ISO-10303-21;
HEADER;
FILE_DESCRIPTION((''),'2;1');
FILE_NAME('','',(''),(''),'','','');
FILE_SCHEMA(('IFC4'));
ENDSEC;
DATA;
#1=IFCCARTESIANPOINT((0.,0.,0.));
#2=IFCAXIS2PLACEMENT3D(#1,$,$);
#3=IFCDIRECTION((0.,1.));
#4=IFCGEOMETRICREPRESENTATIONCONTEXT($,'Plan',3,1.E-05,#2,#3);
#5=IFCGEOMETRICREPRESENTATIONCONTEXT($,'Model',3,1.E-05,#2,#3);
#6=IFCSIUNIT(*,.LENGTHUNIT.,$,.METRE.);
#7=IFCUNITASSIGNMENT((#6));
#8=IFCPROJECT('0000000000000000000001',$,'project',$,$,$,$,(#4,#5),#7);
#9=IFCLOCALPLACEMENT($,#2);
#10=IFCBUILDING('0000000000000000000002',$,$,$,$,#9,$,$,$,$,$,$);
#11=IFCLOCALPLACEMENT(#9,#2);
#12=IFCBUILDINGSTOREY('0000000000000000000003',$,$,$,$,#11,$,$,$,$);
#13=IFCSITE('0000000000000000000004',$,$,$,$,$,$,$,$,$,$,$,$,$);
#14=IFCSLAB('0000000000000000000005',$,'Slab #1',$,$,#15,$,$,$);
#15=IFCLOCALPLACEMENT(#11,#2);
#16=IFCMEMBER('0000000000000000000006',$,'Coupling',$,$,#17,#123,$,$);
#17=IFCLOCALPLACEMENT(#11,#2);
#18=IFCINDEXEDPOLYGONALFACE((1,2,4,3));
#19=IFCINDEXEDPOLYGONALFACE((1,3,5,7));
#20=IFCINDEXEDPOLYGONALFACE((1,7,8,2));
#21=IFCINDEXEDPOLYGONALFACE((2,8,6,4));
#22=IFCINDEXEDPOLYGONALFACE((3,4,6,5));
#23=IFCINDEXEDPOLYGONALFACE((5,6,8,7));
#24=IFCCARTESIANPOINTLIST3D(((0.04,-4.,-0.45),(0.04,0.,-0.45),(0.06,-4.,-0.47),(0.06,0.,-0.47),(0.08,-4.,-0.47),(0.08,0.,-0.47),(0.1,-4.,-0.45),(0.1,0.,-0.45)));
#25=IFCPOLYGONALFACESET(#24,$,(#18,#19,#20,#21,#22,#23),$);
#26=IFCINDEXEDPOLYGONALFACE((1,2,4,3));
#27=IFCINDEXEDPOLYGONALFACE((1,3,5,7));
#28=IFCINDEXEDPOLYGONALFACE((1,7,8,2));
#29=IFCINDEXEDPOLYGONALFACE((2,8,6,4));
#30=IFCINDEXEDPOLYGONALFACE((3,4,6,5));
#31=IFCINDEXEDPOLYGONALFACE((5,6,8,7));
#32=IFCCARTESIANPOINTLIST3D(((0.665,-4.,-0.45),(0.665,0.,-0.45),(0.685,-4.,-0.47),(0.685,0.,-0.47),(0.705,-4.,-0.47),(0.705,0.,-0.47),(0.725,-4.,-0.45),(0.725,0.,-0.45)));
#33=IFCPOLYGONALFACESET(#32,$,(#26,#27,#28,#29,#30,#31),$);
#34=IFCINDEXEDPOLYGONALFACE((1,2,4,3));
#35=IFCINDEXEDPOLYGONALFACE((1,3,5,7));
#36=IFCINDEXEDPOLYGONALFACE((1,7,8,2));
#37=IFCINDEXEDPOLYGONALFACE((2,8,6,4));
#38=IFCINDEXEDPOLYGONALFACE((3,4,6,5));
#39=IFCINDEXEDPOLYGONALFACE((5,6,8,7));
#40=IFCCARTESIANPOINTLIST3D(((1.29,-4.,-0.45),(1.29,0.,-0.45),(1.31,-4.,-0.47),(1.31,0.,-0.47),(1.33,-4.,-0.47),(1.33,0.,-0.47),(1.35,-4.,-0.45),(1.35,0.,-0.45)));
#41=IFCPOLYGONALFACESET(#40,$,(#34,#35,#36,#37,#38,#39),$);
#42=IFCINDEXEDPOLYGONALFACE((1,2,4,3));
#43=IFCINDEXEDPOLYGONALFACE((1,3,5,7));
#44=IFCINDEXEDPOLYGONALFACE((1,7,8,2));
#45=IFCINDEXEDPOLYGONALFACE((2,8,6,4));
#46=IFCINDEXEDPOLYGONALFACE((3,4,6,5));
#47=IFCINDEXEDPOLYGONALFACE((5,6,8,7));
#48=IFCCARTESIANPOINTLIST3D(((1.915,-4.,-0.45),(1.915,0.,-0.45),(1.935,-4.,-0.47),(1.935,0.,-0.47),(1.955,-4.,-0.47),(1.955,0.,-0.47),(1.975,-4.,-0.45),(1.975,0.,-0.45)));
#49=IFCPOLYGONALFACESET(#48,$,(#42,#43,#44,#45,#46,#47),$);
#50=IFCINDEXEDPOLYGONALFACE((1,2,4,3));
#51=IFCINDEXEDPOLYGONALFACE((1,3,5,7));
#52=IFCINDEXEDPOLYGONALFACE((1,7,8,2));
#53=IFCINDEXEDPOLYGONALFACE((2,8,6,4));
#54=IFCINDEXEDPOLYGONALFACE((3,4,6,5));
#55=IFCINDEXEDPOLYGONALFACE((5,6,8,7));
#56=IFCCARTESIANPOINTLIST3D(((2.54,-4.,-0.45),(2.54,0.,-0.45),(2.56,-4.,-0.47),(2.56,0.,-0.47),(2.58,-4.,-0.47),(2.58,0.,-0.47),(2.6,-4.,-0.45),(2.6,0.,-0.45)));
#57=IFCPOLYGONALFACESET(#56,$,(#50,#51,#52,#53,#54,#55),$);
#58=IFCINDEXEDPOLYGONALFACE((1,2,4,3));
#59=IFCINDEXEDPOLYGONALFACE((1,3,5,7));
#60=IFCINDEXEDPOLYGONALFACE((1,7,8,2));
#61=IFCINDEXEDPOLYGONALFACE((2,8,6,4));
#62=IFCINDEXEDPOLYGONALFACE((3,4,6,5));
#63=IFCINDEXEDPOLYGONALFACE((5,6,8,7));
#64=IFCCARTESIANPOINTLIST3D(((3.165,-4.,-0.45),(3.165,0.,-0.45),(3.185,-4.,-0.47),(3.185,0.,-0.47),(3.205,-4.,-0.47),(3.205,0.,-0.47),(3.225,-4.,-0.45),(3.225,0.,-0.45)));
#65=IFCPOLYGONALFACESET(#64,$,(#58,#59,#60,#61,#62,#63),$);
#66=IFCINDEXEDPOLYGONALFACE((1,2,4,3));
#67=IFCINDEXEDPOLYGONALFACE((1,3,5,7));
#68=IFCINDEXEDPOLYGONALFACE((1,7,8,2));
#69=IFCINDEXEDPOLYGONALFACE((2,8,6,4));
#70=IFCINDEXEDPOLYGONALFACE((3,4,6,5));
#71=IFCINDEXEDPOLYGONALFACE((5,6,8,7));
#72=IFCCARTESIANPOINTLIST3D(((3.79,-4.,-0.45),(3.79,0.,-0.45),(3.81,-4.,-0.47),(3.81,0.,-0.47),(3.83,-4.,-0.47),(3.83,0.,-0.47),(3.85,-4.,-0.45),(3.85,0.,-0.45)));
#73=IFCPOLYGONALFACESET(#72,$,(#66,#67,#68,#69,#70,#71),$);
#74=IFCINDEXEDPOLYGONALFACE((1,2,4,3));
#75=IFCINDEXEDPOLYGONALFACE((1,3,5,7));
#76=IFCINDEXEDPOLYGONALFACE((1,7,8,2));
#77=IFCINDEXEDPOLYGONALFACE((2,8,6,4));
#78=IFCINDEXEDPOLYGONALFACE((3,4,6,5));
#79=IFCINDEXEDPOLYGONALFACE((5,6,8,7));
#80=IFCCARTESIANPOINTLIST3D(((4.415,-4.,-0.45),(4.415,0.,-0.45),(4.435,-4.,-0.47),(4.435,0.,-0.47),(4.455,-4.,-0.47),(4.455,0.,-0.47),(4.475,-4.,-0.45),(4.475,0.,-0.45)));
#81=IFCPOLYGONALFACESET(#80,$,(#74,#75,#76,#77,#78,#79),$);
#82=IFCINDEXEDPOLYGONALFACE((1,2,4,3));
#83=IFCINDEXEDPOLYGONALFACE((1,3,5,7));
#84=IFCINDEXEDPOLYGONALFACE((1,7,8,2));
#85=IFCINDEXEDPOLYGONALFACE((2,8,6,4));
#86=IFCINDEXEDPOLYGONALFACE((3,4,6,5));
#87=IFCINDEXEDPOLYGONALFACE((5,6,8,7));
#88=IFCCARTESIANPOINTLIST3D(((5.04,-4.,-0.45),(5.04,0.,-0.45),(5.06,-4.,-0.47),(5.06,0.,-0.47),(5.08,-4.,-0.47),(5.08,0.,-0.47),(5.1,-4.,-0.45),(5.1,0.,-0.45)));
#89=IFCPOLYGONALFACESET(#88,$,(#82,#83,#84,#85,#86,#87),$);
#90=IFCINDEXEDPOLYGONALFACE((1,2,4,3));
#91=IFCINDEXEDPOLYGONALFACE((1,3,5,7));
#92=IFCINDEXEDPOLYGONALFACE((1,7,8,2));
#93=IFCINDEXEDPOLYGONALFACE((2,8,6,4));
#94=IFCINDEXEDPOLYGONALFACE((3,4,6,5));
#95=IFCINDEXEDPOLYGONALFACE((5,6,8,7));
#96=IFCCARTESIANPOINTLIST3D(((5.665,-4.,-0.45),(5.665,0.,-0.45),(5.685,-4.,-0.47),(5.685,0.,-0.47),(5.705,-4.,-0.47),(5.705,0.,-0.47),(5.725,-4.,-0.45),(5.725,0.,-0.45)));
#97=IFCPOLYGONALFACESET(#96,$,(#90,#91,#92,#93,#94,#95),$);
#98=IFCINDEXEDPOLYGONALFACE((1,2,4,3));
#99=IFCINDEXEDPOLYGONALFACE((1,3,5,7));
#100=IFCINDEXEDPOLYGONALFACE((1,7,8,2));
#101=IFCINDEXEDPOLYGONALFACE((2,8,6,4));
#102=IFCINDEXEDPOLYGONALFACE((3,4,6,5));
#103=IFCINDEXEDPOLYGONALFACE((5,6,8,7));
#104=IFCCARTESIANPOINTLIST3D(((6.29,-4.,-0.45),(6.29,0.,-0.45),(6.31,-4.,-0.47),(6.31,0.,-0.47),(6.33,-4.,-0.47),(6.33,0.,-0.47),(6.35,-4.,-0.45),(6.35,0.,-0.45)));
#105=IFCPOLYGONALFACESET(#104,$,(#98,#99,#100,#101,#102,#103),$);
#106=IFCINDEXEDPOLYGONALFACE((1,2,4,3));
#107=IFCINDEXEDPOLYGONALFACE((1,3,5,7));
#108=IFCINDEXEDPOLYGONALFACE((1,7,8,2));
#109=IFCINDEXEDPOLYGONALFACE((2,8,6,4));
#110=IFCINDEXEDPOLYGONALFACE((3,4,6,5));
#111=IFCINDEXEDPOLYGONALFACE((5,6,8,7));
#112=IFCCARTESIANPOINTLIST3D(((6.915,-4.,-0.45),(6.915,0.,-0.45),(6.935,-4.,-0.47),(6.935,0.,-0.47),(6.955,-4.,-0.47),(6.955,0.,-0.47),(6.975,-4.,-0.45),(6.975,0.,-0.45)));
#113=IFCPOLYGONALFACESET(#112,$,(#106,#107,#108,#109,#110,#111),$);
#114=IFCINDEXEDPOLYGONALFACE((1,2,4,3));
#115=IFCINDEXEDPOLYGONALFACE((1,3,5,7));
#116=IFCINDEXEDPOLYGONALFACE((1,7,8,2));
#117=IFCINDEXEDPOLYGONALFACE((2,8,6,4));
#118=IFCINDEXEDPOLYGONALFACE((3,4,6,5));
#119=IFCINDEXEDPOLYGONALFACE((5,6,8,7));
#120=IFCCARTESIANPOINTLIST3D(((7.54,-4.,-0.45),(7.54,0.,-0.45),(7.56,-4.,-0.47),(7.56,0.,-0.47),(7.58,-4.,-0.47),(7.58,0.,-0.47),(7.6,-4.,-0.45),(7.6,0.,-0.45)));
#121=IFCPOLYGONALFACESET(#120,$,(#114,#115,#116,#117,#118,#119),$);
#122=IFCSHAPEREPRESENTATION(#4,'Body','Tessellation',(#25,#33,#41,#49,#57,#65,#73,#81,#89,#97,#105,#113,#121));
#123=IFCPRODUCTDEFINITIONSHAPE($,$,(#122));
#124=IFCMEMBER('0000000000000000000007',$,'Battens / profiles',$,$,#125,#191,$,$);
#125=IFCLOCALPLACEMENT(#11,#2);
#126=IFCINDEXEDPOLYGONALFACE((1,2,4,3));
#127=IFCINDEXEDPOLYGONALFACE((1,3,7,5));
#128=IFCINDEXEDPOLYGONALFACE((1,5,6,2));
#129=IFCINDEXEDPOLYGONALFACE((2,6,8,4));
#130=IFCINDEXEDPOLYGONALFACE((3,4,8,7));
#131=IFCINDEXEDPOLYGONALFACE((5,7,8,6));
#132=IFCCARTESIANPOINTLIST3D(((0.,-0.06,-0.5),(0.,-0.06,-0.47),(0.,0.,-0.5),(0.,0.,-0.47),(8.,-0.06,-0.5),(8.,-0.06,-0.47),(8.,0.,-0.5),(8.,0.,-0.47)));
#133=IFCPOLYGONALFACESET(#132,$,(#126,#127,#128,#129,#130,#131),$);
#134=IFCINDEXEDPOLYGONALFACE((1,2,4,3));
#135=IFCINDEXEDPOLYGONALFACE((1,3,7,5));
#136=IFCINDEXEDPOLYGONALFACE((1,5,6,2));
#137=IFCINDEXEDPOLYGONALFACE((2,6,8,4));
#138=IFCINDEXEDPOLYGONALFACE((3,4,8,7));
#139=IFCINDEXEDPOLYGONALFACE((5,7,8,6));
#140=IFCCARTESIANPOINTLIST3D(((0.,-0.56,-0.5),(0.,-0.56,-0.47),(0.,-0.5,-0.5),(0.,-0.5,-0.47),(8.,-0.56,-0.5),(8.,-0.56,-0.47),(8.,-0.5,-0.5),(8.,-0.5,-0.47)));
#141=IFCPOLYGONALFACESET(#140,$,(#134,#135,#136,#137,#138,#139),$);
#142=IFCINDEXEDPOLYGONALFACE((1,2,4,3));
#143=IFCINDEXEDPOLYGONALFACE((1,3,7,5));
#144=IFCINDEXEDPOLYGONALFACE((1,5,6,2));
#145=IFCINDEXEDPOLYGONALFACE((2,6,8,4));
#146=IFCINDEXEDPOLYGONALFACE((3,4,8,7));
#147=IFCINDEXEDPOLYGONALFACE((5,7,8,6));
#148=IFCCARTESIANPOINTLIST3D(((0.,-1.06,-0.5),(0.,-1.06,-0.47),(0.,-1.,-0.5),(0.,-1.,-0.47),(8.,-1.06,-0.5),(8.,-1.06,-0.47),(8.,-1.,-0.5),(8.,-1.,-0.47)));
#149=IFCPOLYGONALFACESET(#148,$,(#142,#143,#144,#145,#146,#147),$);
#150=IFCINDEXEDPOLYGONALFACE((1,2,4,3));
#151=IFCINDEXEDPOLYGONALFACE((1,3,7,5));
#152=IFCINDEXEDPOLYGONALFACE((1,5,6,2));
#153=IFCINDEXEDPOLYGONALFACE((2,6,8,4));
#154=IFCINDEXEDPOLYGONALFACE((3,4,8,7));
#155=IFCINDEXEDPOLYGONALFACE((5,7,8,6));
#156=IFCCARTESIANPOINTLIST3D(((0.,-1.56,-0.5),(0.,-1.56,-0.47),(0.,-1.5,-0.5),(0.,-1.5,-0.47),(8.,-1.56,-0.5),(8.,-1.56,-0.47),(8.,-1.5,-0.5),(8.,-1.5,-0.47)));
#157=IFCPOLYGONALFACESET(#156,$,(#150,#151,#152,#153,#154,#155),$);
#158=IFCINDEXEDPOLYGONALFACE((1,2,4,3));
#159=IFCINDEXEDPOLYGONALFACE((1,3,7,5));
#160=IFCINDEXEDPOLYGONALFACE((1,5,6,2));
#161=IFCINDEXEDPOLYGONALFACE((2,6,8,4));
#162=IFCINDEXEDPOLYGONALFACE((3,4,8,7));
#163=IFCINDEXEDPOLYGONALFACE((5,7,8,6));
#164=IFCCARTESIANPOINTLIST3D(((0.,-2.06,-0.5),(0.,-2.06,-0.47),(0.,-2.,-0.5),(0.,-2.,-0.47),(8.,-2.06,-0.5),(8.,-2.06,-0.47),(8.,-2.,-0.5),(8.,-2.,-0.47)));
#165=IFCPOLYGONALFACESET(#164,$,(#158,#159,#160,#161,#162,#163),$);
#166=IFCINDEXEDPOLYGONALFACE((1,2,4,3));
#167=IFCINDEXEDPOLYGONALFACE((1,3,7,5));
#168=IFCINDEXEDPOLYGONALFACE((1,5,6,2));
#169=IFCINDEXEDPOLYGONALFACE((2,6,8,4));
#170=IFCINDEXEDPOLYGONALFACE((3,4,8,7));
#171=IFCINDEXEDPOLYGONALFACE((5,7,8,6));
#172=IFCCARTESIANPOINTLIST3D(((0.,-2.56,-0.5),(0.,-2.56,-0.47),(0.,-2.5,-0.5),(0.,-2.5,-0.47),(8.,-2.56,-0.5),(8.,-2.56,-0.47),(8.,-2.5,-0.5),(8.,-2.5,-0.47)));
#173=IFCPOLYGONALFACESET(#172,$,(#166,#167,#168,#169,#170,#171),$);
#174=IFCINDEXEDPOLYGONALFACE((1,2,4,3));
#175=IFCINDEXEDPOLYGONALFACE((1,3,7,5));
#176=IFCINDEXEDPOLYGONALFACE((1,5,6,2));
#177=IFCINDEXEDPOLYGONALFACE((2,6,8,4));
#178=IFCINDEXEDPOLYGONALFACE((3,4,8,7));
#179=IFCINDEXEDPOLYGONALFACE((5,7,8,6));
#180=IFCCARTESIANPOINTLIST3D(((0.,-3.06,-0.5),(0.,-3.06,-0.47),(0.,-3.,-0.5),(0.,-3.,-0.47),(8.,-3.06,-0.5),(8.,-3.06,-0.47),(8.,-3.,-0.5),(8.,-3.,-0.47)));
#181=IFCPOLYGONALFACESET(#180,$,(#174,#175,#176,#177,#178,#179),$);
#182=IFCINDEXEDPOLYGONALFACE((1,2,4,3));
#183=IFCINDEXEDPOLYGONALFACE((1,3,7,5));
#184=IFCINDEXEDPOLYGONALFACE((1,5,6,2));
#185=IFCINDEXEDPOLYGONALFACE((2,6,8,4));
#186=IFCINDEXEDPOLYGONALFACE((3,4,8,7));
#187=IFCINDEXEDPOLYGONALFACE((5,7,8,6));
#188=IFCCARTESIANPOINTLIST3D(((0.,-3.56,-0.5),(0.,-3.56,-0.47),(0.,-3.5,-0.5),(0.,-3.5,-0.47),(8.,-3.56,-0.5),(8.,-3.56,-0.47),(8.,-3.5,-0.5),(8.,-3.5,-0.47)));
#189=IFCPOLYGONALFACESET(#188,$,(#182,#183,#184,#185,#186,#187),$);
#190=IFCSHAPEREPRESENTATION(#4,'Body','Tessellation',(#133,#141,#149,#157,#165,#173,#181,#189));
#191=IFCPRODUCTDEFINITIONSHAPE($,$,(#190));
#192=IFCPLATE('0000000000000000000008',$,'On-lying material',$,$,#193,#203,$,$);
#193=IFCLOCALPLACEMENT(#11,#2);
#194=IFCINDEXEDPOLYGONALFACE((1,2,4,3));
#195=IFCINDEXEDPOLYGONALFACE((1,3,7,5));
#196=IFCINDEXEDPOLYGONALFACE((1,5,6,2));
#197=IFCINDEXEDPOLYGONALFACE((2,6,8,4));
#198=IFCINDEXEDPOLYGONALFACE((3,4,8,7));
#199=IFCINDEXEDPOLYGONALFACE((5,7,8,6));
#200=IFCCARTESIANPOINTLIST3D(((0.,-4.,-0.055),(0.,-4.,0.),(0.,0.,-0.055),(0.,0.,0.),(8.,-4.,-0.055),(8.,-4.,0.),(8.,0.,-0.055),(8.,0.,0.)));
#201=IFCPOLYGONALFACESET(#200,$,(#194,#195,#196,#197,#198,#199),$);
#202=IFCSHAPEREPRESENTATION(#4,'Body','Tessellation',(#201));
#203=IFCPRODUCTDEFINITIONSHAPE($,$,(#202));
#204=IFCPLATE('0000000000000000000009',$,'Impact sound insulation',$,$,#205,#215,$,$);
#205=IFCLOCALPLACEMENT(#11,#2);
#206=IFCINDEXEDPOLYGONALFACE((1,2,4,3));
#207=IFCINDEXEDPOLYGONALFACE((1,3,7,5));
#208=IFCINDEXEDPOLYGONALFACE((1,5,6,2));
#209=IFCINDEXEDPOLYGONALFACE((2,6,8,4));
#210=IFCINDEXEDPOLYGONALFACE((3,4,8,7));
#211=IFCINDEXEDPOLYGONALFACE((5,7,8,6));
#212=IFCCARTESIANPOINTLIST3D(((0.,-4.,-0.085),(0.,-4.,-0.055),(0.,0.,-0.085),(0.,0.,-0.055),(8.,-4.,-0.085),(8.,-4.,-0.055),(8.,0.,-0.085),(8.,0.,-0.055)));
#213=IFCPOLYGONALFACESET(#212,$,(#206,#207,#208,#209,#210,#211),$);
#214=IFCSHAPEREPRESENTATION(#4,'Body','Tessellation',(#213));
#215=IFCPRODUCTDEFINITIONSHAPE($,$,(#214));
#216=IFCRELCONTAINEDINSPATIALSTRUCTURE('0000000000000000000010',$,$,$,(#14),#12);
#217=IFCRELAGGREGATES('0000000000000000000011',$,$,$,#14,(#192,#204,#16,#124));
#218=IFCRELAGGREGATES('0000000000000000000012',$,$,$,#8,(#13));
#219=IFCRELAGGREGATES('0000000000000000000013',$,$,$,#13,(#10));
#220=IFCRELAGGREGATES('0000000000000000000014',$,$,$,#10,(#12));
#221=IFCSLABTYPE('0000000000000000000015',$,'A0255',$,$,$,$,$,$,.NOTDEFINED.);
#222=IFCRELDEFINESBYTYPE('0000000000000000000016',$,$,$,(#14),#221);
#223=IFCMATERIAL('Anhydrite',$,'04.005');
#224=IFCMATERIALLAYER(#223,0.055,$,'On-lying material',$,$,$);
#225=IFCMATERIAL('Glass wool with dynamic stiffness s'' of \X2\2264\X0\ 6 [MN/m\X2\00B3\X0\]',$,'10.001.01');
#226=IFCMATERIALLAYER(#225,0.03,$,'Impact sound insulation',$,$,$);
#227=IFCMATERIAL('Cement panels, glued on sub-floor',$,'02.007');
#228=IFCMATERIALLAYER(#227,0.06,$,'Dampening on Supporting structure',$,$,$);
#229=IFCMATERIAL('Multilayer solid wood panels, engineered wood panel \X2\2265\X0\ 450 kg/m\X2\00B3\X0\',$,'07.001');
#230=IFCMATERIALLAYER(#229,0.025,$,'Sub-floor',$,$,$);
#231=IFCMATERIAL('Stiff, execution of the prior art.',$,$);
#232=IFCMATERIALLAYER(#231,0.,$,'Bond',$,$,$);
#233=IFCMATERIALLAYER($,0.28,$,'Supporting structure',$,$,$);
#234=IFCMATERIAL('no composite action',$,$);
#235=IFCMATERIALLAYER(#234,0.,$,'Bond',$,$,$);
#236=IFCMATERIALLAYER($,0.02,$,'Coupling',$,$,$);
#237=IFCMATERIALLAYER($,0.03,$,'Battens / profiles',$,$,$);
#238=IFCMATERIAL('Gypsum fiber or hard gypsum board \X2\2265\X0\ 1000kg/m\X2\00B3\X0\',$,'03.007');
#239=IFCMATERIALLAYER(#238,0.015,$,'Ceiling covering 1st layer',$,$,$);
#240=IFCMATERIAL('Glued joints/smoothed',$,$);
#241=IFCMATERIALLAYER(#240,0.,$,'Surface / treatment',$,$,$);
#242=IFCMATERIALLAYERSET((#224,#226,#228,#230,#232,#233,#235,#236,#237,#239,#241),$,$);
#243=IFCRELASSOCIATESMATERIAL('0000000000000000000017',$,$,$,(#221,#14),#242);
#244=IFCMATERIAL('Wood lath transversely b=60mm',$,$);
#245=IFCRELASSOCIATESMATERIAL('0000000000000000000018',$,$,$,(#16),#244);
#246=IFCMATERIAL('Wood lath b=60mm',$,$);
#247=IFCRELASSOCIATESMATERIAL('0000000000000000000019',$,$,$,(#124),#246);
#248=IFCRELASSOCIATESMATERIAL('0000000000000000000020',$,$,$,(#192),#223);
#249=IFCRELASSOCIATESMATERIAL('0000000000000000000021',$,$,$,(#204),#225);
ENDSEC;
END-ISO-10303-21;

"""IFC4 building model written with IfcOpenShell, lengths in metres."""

from ifc_helpers import new_model, si_unit, direction, frame, frame_2d, origin, origin_with_axes, place, context, project, spatial, polyline, rectangle, outline, extrude, material, layer, layer_set, type_object, element, aggregate, save


model = new_model("IFC4")

# Units and contexts
plan_context = context("Plan", 3, precision=1e-05, world=origin(), true_north=direction((0.0, 1.0)))
model_context = context("Model", 3, precision=1e-05, world=origin(), true_north=direction((0.0, 1.0)))
ifc_project = project(units=[si_unit("LENGTHUNIT", "METRE")], contexts=[plan_context, model_context])

# Site, building, storey
site = spatial("IfcSite", under=ifc_project)
building_placement = place(None, origin())
building = spatial("IfcBuilding", under=site, at=building_placement)
storey_placement = place(building_placement, origin())
storey = spatial("IfcBuildingStorey", under=building, at=storey_placement)

# Slab, members, plates
ifc_material_1 = material(Name="Anhydrite", Category="04.005")
ifc_layer_1 = layer(ifc_material_1, 0.055, Name="On-lying material")
ifc_material_2 = material(Name="Glass wool with dynamic stiffness s' of ≤ 6 [MN/m³]", Category="10.001.01")
ifc_layer_2 = layer(ifc_material_2, 0.03, Name="Impact sound insulation")
ifc_material_3 = material(Name="Cement panels, glued on sub-floor", Category="02.007")
ifc_layer_3 = layer(ifc_material_3, 0.06, Name="Dampening on Supporting structure")
ifc_material_4 = material(Name="Multilayer solid wood panels, engineered wood panel ≥ 450 kg/m³", Category="07.001")
ifc_layer_4 = layer(ifc_material_4, 0.025, Name="Sub-floor")
ifc_material_5 = material(Name="Stiff, execution of the prior art.")
ifc_layer_5 = layer(ifc_material_5, 0.0, Name="Bond")
ifc_layer_6 = layer(None, 0.28, Name="Supporting structure")
ifc_material_6 = material(Name="no composite action")
ifc_layer_7 = layer(ifc_material_6, 0.0, Name="Bond")
ifc_layer_8 = layer(None, 0.02, Name="Coupling")
ifc_layer_9 = layer(None, 0.03, Name="Battens / profiles")
ifc_material_7 = material(Name="Gypsum fiber or hard gypsum board ≥ 1000kg/m³", Category="03.007")
ifc_layer_10 = layer(ifc_material_7, 0.015, Name="Ceiling covering 1st layer")
ifc_material_8 = material(Name="Glued joints/smoothed")
ifc_layer_11 = layer(ifc_material_8, 0.0, Name="Surface / treatment")
ifc_layer_set = layer_set([ifc_layer_1, ifc_layer_2, ifc_layer_3, ifc_layer_4, ifc_layer_5, ifc_layer_6, ifc_layer_7, ifc_layer_8, ifc_layer_9, ifc_layer_10, ifc_layer_11])
slab_type = type_object("IfcSlabType", Name="A0255", PredefinedType="NOTDEFINED", material=ifc_layer_set)
slab_placement = place(None, frame((0.0, 0.0, 0.0), z_axis=(0.0, 0.0, -1.0), x_axis=(1.0, 0.0, 0.0)))
slab = element("IfcSlab", 1, at=slab_placement, inside=storey, type_object=slab_type, material=ifc_layer_set, Name="Slab #1")
ifc_material_9 = material(Name="Wood lath transversely b=60mm")
member_1_placement = place(slab_placement, origin())
member_1 = element("IfcMember", 2, at=member_1_placement, material=ifc_material_9, Name="Coupling", context=plan_context, shape_type="SweptSolid", body=[
    extrude(outline(polyline([(0.0, 0.0), (0.06, 0.0), (0.04, 0.02), (0.02, 0.02), (0.0, 0.0)])), frame((0.04, 4.0, 0.45), z_axis=(0.0, -1.0, 0.0), x_axis=(1.0, 0.0, 0.0)), (0.0, 0.0, 1.0), 4.0),
    extrude(outline(polyline([(0.0, 0.0), (0.06, 0.0), (0.04, 0.02), (0.02, 0.02), (0.0, 0.0)])), frame((0.665, 4.0, 0.45), z_axis=(0.0, -1.0, 0.0), x_axis=(1.0, 0.0, 0.0)), (0.0, 0.0, 1.0), 4.0),
    extrude(outline(polyline([(0.0, 0.0), (0.06, 0.0), (0.04, 0.02), (0.02, 0.02), (0.0, 0.0)])), frame((1.29, 4.0, 0.45), z_axis=(0.0, -1.0, 0.0), x_axis=(1.0, 0.0, 0.0)), (0.0, 0.0, 1.0), 4.0),
    extrude(outline(polyline([(0.0, 0.0), (0.06, 0.0), (0.04, 0.02), (0.02, 0.02), (0.0, 0.0)])), frame((1.915, 4.0, 0.45), z_axis=(0.0, -1.0, 0.0), x_axis=(1.0, 0.0, 0.0)), (0.0, 0.0, 1.0), 4.0),
    extrude(outline(polyline([(0.0, 0.0), (0.06, 0.0), (0.04, 0.02), (0.02, 0.02), (0.0, 0.0)])), frame((2.54, 4.0, 0.45), z_axis=(0.0, -1.0, 0.0), x_axis=(1.0, 0.0, 0.0)), (0.0, 0.0, 1.0), 4.0),
    extrude(outline(polyline([(0.0, 0.0), (0.06, 0.0), (0.04, 0.02), (0.02, 0.02), (0.0, 0.0)])), frame((3.165, 4.0, 0.45), z_axis=(0.0, -1.0, 0.0), x_axis=(1.0, 0.0, 0.0)), (0.0, 0.0, 1.0), 4.0),
    extrude(outline(polyline([(0.0, 0.0), (0.06, 0.0), (0.04, 0.02), (0.02, 0.02), (0.0, 0.0)])), frame((3.79, 4.0, 0.45), z_axis=(0.0, -1.0, 0.0), x_axis=(1.0, 0.0, 0.0)), (0.0, 0.0, 1.0), 4.0),
    extrude(outline(polyline([(0.0, 0.0), (0.06, 0.0), (0.04, 0.02), (0.02, 0.02), (0.0, 0.0)])), frame((4.415, 4.0, 0.45), z_axis=(0.0, -1.0, 0.0), x_axis=(1.0, 0.0, 0.0)), (0.0, 0.0, 1.0), 4.0),
    extrude(outline(polyline([(0.0, 0.0), (0.06, 0.0), (0.04, 0.02), (0.02, 0.02), (0.0, 0.0)])), frame((5.04, 4.0, 0.45), z_axis=(0.0, -1.0, 0.0), x_axis=(1.0, 0.0, 0.0)), (0.0, 0.0, 1.0), 4.0),
    extrude(outline(polyline([(0.0, 0.0), (0.06, 0.0), (0.04, 0.02), (0.02, 0.02), (0.0, 0.0)])), frame((5.665, 4.0, 0.45), z_axis=(0.0, -1.0, 0.0), x_axis=(1.0, 0.0, 0.0)), (0.0, 0.0, 1.0), 4.0),
    extrude(outline(polyline([(0.0, 0.0), (0.06, 0.0), (0.04, 0.02), (0.02, 0.02), (0.0, 0.0)])), frame((6.29, 4.0, 0.45), z_axis=(0.0, -1.0, 0.0), x_axis=(1.0, 0.0, 0.0)), (0.0, 0.0, 1.0), 4.0),
    extrude(outline(polyline([(0.0, 0.0), (0.06, 0.0), (0.04, 0.02), (0.02, 0.02), (0.0, 0.0)])), frame((6.915, 4.0, 0.45), z_axis=(0.0, -1.0, 0.0), x_axis=(1.0, 0.0, 0.0)), (0.0, 0.0, 1.0), 4.0),
    extrude(outline(polyline([(0.0, 0.0), (0.06, 0.0), (0.04, 0.02), (0.02, 0.02), (0.0, 0.0)])), frame((7.54, 4.0, 0.45), z_axis=(0.0, -1.0, 0.0), x_axis=(1.0, 0.0, 0.0)), (0.0, 0.0, 1.0), 4.0),
])
ifc_material_10 = material(Name="Wood lath b=60mm")
member_2_placement = place(slab_placement, origin())
member_2 = element("IfcMember", 3, at=member_2_placement, material=ifc_material_10, Name="Battens / profiles", context=plan_context, shape_type="SweptSolid", body=[
    extrude(rectangle(XDim=0.06, YDim=0.03, at=frame_2d((0.03, 0.015), x_axis=(1.0, 0.0))), frame((0.0, 0.0, 0.47), z_axis=(1.0, 0.0, 0.0), x_axis=(0.0, 1.0, 0.0)), (0.0, 0.0, 1.0), 8.0),
    extrude(rectangle(XDim=0.06, YDim=0.03, at=frame_2d((0.03, 0.015), x_axis=(1.0, 0.0))), frame((0.0, 0.5, 0.47), z_axis=(1.0, 0.0, 0.0), x_axis=(0.0, 1.0, 0.0)), (0.0, 0.0, 1.0), 8.0),
    extrude(rectangle(XDim=0.06, YDim=0.03, at=frame_2d((0.03, 0.015), x_axis=(1.0, 0.0))), frame((0.0, 1.0, 0.47), z_axis=(1.0, 0.0, 0.0), x_axis=(0.0, 1.0, 0.0)), (0.0, 0.0, 1.0), 8.0),
    extrude(rectangle(XDim=0.06, YDim=0.03, at=frame_2d((0.03, 0.015), x_axis=(1.0, 0.0))), frame((0.0, 1.5, 0.47), z_axis=(1.0, 0.0, 0.0), x_axis=(0.0, 1.0, 0.0)), (0.0, 0.0, 1.0), 8.0),
    extrude(rectangle(XDim=0.06, YDim=0.03, at=frame_2d((0.03, 0.015), x_axis=(1.0, 0.0))), frame((0.0, 2.0, 0.47), z_axis=(1.0, 0.0, 0.0), x_axis=(0.0, 1.0, 0.0)), (0.0, 0.0, 1.0), 8.0),
    extrude(rectangle(XDim=0.06, YDim=0.03, at=frame_2d((0.03, 0.015), x_axis=(1.0, 0.0))), frame((0.0, 2.5, 0.47), z_axis=(1.0, 0.0, 0.0), x_axis=(0.0, 1.0, 0.0)), (0.0, 0.0, 1.0), 8.0),
    extrude(rectangle(XDim=0.06, YDim=0.03, at=frame_2d((0.03, 0.015), x_axis=(1.0, 0.0))), frame((0.0, 3.0, 0.47), z_axis=(1.0, 0.0, 0.0), x_axis=(0.0, 1.0, 0.0)), (0.0, 0.0, 1.0), 8.0),
    extrude(rectangle(XDim=0.06, YDim=0.03, at=frame_2d((0.03, 0.015), x_axis=(1.0, 0.0))), frame((0.0, 3.5, 0.47), z_axis=(1.0, 0.0, 0.0), x_axis=(0.0, 1.0, 0.0)), (0.0, 0.0, 1.0), 8.0),
])
plate_1_placement = place(slab_placement, origin())
plate_1 = element("IfcPlate", 4, at=plate_1_placement, material=ifc_material_1, Name="On-lying material", context=plan_context, shape_type="SweptSolid", body=[
    extrude(rectangle(XDim=8.0, YDim=4.0, at=frame_2d((4.0, 2.0), x_axis=(1.0, 0.0))), origin_with_axes(), (0.0, 0.0, 1.0), 0.055),
])
plate_2_placement = place(slab_placement, origin())
plate_2 = element("IfcPlate", 5, at=plate_2_placement, material=ifc_material_2, Name="Impact sound insulation", context=plan_context, shape_type="SweptSolid", body=[
    extrude(rectangle(XDim=8.0, YDim=4.0, at=frame_2d((4.0, 2.0), x_axis=(1.0, 0.0))), frame((0.0, 0.0, 0.055), z_axis=(0.0, 0.0, 1.0), x_axis=(1.0, 0.0, 0.0)), (0.0, 0.0, 1.0), 0.03),
])
aggregate(slab, [plate_1, plate_2, member_1, member_2])

save(model, "model.ifc")
